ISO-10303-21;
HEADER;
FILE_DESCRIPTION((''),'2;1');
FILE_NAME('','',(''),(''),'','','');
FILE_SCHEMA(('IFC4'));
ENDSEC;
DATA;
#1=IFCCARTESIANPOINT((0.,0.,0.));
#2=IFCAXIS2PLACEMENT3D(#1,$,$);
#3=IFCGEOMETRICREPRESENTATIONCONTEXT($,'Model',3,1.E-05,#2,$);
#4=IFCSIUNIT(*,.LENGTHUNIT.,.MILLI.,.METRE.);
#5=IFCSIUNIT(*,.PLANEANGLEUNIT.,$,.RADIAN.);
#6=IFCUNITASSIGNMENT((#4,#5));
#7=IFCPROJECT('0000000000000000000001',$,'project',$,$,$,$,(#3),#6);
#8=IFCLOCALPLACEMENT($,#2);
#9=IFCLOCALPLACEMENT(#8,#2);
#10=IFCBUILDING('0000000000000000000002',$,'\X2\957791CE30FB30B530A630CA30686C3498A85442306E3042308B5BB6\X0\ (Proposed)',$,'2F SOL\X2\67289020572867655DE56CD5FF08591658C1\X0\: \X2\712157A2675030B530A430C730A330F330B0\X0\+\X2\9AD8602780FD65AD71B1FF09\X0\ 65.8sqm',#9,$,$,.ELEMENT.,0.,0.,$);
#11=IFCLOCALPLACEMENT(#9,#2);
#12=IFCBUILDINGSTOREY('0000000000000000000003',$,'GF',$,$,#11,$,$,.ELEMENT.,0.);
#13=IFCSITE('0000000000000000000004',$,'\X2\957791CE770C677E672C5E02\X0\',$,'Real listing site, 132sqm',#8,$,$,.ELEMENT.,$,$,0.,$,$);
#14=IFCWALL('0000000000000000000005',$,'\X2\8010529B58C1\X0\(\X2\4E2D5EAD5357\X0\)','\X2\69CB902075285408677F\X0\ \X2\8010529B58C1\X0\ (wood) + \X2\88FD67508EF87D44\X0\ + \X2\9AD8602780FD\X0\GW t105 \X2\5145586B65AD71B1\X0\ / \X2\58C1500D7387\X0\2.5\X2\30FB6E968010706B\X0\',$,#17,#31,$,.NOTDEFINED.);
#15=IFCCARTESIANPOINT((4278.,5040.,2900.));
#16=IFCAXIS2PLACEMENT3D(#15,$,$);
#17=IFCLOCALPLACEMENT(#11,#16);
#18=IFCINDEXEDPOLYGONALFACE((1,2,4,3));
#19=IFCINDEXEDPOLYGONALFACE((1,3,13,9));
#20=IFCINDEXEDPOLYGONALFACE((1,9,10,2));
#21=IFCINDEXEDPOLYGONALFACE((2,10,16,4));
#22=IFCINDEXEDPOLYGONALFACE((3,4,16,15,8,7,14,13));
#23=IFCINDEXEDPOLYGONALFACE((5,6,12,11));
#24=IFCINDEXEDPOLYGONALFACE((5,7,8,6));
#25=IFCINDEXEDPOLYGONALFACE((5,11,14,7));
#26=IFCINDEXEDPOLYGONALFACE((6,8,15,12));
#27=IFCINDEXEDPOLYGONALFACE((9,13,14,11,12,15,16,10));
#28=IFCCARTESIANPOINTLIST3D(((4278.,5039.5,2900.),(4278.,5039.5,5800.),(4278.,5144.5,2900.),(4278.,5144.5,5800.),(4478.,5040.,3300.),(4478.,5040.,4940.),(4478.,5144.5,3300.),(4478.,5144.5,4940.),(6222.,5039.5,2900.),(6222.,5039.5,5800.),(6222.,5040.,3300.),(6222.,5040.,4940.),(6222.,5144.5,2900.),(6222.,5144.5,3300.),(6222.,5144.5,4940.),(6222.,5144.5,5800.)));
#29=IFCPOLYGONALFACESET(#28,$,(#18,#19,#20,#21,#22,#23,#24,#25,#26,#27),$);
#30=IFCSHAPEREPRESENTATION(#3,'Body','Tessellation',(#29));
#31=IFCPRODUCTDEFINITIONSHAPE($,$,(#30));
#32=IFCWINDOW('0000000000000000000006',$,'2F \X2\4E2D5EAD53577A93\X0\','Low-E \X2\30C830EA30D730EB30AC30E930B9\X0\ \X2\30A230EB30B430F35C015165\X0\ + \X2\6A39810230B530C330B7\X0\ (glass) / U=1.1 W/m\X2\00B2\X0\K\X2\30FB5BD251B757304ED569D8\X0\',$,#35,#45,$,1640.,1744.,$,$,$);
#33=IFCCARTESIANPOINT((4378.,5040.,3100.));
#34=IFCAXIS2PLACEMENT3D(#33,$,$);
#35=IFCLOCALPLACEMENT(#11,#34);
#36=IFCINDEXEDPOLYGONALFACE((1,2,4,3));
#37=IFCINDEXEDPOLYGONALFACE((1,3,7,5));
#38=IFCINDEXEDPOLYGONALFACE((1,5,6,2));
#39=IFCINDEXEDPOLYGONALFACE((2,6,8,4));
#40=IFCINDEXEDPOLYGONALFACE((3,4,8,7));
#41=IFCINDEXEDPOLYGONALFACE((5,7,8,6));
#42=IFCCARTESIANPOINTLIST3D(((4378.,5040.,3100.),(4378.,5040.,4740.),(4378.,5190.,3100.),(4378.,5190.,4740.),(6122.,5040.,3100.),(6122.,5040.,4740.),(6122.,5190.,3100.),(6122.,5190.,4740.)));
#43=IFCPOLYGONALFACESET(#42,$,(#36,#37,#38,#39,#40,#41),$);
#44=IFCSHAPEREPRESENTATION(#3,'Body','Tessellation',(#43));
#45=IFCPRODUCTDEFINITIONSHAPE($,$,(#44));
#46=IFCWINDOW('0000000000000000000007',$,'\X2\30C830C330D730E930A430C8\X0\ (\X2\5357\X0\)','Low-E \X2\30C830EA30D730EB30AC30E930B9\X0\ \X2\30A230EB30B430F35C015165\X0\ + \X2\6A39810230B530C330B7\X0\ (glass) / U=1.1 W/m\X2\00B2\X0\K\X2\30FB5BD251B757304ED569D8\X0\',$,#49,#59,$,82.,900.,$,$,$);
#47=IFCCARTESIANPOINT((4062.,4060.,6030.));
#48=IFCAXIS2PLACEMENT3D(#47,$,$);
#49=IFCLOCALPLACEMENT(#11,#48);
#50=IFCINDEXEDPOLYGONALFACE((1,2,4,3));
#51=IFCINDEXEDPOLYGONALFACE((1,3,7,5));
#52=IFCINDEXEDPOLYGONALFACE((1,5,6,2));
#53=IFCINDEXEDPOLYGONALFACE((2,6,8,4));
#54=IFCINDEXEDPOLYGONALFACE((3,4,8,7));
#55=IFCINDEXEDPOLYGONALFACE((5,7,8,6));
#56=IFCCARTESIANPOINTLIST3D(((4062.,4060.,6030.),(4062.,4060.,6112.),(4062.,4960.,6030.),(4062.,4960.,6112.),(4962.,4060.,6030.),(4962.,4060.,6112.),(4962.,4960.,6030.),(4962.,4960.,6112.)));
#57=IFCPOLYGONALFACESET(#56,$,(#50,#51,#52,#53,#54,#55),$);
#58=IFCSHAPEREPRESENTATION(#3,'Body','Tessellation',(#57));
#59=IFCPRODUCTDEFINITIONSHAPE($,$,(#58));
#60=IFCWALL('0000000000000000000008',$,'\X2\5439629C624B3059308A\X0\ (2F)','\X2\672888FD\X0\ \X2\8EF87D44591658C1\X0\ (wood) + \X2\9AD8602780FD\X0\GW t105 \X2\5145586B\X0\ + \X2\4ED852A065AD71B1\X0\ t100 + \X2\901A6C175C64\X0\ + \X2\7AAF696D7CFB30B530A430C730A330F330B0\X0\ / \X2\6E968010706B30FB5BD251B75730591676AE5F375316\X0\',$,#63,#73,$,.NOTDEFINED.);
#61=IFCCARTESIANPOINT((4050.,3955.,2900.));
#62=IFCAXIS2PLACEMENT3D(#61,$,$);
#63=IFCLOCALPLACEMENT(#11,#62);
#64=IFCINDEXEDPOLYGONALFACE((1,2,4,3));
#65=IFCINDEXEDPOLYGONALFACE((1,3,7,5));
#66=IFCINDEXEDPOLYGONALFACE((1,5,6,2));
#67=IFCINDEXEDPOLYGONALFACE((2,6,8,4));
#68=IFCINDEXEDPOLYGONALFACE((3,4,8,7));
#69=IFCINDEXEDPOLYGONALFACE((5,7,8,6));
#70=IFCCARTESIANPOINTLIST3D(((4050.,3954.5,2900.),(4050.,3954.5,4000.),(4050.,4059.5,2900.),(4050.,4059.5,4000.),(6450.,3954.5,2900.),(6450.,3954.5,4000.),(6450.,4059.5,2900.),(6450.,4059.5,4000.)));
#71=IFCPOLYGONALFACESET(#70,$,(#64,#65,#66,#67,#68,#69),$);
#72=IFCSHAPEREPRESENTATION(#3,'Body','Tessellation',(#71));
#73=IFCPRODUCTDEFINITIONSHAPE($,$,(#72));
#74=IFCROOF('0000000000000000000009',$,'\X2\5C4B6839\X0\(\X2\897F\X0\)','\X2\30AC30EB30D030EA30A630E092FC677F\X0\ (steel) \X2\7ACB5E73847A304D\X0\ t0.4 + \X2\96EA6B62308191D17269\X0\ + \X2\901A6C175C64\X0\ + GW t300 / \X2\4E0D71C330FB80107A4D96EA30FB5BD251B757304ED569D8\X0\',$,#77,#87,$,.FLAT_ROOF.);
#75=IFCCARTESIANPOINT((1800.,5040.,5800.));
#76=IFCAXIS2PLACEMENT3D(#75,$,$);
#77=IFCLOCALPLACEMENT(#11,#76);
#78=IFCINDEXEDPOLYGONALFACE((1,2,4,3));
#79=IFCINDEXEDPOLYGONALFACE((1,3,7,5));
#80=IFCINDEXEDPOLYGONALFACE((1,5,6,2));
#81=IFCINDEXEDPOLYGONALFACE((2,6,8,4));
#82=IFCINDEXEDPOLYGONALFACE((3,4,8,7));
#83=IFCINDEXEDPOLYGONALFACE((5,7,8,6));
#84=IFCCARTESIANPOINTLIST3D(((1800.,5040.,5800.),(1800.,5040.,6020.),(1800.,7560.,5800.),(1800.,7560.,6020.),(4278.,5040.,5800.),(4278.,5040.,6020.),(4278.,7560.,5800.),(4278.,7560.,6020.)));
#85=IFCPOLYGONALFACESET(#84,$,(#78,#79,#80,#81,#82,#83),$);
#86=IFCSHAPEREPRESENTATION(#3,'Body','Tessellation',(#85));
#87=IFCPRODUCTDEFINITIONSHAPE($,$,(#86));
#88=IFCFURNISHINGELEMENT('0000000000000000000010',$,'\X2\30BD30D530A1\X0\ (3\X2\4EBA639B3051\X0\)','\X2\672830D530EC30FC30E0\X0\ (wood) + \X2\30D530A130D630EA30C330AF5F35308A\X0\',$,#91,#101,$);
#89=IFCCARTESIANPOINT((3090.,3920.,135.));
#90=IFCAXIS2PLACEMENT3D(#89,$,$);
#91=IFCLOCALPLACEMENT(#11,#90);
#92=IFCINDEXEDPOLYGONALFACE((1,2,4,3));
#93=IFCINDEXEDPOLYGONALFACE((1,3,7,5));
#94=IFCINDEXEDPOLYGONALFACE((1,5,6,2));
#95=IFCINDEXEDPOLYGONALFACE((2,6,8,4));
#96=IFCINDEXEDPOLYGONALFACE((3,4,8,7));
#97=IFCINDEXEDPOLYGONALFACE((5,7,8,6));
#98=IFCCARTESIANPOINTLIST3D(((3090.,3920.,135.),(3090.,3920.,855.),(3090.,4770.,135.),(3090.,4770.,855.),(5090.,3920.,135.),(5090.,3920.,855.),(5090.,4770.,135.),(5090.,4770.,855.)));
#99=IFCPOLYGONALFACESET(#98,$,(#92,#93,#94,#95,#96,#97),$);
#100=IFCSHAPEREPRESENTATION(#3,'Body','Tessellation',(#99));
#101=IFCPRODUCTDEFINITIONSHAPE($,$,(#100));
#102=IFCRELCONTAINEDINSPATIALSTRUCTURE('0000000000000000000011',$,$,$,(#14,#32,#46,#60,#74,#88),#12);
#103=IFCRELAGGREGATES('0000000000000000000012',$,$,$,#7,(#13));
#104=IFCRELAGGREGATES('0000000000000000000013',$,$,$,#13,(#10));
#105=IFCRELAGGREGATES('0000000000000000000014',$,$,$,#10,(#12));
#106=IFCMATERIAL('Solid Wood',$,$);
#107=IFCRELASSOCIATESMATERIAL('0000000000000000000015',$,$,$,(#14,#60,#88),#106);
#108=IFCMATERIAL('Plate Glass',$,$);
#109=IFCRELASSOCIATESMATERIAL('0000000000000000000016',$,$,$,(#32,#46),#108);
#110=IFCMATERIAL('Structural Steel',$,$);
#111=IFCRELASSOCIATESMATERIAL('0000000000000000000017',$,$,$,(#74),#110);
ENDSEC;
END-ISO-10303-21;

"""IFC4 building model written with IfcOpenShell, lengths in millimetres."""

from ifc_helpers import new_model, si_unit, frame, frame_2d, origin, place, context, project, spatial, rectangle, extrude, material, element, fill, save


model = new_model("IFC4")

# Units and contexts
model_context = context("Model", 3, precision=1e-05, world=origin())
ifc_project = project(units=[si_unit("LENGTHUNIT", "METRE", prefix="MILLI"), si_unit("PLANEANGLEUNIT", "RADIAN")], contexts=[model_context])

# Site, building, storey
site_placement = place(None, origin())
site = spatial("IfcSite", under=ifc_project, at=site_placement, Name="長野県松本市", ObjectType="Real listing site, 132sqm", CompositionType="ELEMENT", RefElevation=0.0)
building_placement = place(site_placement, origin())
building = spatial("IfcBuilding", under=site, at=building_placement, Name="長野・サウナと水風呂のある家 (Proposed)", ObjectType="2F SOL木造在来工法（外壁: 無垢材サイディング+高性能断熱） 65.8sqm", CompositionType="ELEMENT", ElevationOfRefHeight=0.0, ElevationOfTerrain=0.0)
storey_placement = place(building_placement, origin())
storey = spatial("IfcBuildingStorey", under=building, at=storey_placement, Name="GF", CompositionType="ELEMENT", Elevation=0.0)

# Shared definitions
ifc_material_1 = material(Name="Solid Wood")

# Shared definitions
ifc_material_2 = material(Name="Plate Glass")

# Wall, opening, window
wall_1_placement = place(storey_placement, frame((4278.0, 5040.0, 2900.0)))
wall_1 = element("IfcWall", 1, at=wall_1_placement, inside=storey, material=ifc_material_1, Name="耐力壁(中庭南)", Description="構造用合板 耐力壁 (wood) + 製材軸組 + 高性能GW t105 充填断熱 / 壁倍率2.5・準耐火", PredefinedType="NOTDEFINED", context=model_context, shape_type="SweptSolid", body=[
    extrude(rectangle(XDim=1944.0, YDim=105.0, at=frame_2d((972.0, 52.0))), frame((4278.0, 5040.0, 2900.0)), (0.0, 0.0, 1.0), 2900.0),
])
opening_1_placement = place(storey_placement, frame((4378.0, 5040.0, 3100.0)))
opening_1 = element("IfcOpeningElement", 2, at=opening_1_placement, cuts=wall_1, PredefinedType="NOTDEFINED", context=model_context, shape_type="SweptSolid", body=[
    extrude(rectangle(XDim=1744.0, YDim=150.0, at=frame_2d((872.0, 75.0))), frame((4378.0, 5040.0, 3100.0)), (0.0, 0.0, 1.0), 1640.0),
])
window_1_placement = place(storey_placement, frame((4378.0, 5040.0, 3100.0)))
window_1 = element("IfcWindow", 3, at=window_1_placement, inside=storey, material=ifc_material_2, Name="2F 中庭南窓", Description="Low-E トリプルガラス アルゴン封入 + 樹脂サッシ (glass) / U=1.1 W/m²K・寒冷地仕様", OverallHeight=1640.0, OverallWidth=1744.0, context=model_context, shape_type="SweptSolid", body=[
    extrude(rectangle(XDim=1744.0, YDim=150.0, at=frame_2d((872.0, 75.0))), frame((4378.0, 5040.0, 3100.0)), (0.0, 0.0, 1.0), 1640.0),
])
fill(opening_1, window_1)

# Window
window_2_placement = place(storey_placement, frame((4062.0, 4060.0, 6030.0)))
element("IfcWindow", 4, at=window_2_placement, inside=storey, material=ifc_material_2, Name="トップライト (南)", Description="Low-E トリプルガラス アルゴン封入 + 樹脂サッシ (glass) / U=1.1 W/m²K・寒冷地仕様", OverallHeight=82.0, OverallWidth=900.0, context=model_context, shape_type="SweptSolid", body=[
    extrude(rectangle(XDim=900.0, YDim=900.0, at=frame_2d((450.0, 450.0))), frame((4062.0, 4060.0, 6030.0)), (0.0, 0.0, 1.0), 82.0),
])

# Wall
wall_2_placement = place(storey_placement, frame((4050.0, 3955.0, 2900.0)))
element("IfcWall", 5, at=wall_2_placement, inside=storey, material=ifc_material_1, Name="吹抜手すり (2F)", Description="木製 軸組外壁 (wood) + 高性能GW t105 充填 + 付加断熱 t100 + 通気層 + 窯業系サイディング / 準耐火・寒冷地外皮強化", PredefinedType="NOTDEFINED", context=model_context, shape_type="SweptSolid", body=[
    extrude(rectangle(XDim=2400.0, YDim=105.0, at=frame_2d((1200.0, 52.0))), frame((4050.0, 3955.0, 2900.0)), (0.0, 0.0, 1.0), 1100.0),
])

# Roof
ifc_material_3 = material(Name="Structural Steel")
for number, where, name in (
    (6, (1800.0, 5040.0, 5800.0), "屋根(西)"),
):
    element("IfcRoof", number, at=place(storey_placement, frame(where)), inside=storey, material=ifc_material_3, Name=name, Description="ガルバリウム鋼板 (steel) 立平葺き t0.4 + 雪止め金物 + 通気層 + GW t300 / 不燃・耐積雪・寒冷地仕様", PredefinedType="FLAT_ROOF", context=model_context, shape_type="SweptSolid", body=[
        extrude(rectangle(XDim=2478.0, YDim=2520.0, at=frame_2d((1239.0, 1260.0))), frame((1800.0, 5040.0, 5800.0)), (0.0, 0.0, 1.0), 220.0),
    ])

# Furnishing element
furnishing_placement = place(storey_placement, frame((3090.0, 3920.0, 135.0)))
element("IfcFurnishingElement", 7, at=furnishing_placement, inside=storey, material=ifc_material_1, Name="ソファ (3人掛け)", Description="木フレーム (wood) + ファブリック張り", context=model_context, shape_type="SweptSolid", body=[
    extrude(rectangle(XDim=2000.0, YDim=850.0, at=frame_2d((1000.0, 425.0))), frame((3090.0, 3920.0, 135.0)), (0.0, 0.0, 1.0), 720.0),
])

save(model, "model.ifc")
